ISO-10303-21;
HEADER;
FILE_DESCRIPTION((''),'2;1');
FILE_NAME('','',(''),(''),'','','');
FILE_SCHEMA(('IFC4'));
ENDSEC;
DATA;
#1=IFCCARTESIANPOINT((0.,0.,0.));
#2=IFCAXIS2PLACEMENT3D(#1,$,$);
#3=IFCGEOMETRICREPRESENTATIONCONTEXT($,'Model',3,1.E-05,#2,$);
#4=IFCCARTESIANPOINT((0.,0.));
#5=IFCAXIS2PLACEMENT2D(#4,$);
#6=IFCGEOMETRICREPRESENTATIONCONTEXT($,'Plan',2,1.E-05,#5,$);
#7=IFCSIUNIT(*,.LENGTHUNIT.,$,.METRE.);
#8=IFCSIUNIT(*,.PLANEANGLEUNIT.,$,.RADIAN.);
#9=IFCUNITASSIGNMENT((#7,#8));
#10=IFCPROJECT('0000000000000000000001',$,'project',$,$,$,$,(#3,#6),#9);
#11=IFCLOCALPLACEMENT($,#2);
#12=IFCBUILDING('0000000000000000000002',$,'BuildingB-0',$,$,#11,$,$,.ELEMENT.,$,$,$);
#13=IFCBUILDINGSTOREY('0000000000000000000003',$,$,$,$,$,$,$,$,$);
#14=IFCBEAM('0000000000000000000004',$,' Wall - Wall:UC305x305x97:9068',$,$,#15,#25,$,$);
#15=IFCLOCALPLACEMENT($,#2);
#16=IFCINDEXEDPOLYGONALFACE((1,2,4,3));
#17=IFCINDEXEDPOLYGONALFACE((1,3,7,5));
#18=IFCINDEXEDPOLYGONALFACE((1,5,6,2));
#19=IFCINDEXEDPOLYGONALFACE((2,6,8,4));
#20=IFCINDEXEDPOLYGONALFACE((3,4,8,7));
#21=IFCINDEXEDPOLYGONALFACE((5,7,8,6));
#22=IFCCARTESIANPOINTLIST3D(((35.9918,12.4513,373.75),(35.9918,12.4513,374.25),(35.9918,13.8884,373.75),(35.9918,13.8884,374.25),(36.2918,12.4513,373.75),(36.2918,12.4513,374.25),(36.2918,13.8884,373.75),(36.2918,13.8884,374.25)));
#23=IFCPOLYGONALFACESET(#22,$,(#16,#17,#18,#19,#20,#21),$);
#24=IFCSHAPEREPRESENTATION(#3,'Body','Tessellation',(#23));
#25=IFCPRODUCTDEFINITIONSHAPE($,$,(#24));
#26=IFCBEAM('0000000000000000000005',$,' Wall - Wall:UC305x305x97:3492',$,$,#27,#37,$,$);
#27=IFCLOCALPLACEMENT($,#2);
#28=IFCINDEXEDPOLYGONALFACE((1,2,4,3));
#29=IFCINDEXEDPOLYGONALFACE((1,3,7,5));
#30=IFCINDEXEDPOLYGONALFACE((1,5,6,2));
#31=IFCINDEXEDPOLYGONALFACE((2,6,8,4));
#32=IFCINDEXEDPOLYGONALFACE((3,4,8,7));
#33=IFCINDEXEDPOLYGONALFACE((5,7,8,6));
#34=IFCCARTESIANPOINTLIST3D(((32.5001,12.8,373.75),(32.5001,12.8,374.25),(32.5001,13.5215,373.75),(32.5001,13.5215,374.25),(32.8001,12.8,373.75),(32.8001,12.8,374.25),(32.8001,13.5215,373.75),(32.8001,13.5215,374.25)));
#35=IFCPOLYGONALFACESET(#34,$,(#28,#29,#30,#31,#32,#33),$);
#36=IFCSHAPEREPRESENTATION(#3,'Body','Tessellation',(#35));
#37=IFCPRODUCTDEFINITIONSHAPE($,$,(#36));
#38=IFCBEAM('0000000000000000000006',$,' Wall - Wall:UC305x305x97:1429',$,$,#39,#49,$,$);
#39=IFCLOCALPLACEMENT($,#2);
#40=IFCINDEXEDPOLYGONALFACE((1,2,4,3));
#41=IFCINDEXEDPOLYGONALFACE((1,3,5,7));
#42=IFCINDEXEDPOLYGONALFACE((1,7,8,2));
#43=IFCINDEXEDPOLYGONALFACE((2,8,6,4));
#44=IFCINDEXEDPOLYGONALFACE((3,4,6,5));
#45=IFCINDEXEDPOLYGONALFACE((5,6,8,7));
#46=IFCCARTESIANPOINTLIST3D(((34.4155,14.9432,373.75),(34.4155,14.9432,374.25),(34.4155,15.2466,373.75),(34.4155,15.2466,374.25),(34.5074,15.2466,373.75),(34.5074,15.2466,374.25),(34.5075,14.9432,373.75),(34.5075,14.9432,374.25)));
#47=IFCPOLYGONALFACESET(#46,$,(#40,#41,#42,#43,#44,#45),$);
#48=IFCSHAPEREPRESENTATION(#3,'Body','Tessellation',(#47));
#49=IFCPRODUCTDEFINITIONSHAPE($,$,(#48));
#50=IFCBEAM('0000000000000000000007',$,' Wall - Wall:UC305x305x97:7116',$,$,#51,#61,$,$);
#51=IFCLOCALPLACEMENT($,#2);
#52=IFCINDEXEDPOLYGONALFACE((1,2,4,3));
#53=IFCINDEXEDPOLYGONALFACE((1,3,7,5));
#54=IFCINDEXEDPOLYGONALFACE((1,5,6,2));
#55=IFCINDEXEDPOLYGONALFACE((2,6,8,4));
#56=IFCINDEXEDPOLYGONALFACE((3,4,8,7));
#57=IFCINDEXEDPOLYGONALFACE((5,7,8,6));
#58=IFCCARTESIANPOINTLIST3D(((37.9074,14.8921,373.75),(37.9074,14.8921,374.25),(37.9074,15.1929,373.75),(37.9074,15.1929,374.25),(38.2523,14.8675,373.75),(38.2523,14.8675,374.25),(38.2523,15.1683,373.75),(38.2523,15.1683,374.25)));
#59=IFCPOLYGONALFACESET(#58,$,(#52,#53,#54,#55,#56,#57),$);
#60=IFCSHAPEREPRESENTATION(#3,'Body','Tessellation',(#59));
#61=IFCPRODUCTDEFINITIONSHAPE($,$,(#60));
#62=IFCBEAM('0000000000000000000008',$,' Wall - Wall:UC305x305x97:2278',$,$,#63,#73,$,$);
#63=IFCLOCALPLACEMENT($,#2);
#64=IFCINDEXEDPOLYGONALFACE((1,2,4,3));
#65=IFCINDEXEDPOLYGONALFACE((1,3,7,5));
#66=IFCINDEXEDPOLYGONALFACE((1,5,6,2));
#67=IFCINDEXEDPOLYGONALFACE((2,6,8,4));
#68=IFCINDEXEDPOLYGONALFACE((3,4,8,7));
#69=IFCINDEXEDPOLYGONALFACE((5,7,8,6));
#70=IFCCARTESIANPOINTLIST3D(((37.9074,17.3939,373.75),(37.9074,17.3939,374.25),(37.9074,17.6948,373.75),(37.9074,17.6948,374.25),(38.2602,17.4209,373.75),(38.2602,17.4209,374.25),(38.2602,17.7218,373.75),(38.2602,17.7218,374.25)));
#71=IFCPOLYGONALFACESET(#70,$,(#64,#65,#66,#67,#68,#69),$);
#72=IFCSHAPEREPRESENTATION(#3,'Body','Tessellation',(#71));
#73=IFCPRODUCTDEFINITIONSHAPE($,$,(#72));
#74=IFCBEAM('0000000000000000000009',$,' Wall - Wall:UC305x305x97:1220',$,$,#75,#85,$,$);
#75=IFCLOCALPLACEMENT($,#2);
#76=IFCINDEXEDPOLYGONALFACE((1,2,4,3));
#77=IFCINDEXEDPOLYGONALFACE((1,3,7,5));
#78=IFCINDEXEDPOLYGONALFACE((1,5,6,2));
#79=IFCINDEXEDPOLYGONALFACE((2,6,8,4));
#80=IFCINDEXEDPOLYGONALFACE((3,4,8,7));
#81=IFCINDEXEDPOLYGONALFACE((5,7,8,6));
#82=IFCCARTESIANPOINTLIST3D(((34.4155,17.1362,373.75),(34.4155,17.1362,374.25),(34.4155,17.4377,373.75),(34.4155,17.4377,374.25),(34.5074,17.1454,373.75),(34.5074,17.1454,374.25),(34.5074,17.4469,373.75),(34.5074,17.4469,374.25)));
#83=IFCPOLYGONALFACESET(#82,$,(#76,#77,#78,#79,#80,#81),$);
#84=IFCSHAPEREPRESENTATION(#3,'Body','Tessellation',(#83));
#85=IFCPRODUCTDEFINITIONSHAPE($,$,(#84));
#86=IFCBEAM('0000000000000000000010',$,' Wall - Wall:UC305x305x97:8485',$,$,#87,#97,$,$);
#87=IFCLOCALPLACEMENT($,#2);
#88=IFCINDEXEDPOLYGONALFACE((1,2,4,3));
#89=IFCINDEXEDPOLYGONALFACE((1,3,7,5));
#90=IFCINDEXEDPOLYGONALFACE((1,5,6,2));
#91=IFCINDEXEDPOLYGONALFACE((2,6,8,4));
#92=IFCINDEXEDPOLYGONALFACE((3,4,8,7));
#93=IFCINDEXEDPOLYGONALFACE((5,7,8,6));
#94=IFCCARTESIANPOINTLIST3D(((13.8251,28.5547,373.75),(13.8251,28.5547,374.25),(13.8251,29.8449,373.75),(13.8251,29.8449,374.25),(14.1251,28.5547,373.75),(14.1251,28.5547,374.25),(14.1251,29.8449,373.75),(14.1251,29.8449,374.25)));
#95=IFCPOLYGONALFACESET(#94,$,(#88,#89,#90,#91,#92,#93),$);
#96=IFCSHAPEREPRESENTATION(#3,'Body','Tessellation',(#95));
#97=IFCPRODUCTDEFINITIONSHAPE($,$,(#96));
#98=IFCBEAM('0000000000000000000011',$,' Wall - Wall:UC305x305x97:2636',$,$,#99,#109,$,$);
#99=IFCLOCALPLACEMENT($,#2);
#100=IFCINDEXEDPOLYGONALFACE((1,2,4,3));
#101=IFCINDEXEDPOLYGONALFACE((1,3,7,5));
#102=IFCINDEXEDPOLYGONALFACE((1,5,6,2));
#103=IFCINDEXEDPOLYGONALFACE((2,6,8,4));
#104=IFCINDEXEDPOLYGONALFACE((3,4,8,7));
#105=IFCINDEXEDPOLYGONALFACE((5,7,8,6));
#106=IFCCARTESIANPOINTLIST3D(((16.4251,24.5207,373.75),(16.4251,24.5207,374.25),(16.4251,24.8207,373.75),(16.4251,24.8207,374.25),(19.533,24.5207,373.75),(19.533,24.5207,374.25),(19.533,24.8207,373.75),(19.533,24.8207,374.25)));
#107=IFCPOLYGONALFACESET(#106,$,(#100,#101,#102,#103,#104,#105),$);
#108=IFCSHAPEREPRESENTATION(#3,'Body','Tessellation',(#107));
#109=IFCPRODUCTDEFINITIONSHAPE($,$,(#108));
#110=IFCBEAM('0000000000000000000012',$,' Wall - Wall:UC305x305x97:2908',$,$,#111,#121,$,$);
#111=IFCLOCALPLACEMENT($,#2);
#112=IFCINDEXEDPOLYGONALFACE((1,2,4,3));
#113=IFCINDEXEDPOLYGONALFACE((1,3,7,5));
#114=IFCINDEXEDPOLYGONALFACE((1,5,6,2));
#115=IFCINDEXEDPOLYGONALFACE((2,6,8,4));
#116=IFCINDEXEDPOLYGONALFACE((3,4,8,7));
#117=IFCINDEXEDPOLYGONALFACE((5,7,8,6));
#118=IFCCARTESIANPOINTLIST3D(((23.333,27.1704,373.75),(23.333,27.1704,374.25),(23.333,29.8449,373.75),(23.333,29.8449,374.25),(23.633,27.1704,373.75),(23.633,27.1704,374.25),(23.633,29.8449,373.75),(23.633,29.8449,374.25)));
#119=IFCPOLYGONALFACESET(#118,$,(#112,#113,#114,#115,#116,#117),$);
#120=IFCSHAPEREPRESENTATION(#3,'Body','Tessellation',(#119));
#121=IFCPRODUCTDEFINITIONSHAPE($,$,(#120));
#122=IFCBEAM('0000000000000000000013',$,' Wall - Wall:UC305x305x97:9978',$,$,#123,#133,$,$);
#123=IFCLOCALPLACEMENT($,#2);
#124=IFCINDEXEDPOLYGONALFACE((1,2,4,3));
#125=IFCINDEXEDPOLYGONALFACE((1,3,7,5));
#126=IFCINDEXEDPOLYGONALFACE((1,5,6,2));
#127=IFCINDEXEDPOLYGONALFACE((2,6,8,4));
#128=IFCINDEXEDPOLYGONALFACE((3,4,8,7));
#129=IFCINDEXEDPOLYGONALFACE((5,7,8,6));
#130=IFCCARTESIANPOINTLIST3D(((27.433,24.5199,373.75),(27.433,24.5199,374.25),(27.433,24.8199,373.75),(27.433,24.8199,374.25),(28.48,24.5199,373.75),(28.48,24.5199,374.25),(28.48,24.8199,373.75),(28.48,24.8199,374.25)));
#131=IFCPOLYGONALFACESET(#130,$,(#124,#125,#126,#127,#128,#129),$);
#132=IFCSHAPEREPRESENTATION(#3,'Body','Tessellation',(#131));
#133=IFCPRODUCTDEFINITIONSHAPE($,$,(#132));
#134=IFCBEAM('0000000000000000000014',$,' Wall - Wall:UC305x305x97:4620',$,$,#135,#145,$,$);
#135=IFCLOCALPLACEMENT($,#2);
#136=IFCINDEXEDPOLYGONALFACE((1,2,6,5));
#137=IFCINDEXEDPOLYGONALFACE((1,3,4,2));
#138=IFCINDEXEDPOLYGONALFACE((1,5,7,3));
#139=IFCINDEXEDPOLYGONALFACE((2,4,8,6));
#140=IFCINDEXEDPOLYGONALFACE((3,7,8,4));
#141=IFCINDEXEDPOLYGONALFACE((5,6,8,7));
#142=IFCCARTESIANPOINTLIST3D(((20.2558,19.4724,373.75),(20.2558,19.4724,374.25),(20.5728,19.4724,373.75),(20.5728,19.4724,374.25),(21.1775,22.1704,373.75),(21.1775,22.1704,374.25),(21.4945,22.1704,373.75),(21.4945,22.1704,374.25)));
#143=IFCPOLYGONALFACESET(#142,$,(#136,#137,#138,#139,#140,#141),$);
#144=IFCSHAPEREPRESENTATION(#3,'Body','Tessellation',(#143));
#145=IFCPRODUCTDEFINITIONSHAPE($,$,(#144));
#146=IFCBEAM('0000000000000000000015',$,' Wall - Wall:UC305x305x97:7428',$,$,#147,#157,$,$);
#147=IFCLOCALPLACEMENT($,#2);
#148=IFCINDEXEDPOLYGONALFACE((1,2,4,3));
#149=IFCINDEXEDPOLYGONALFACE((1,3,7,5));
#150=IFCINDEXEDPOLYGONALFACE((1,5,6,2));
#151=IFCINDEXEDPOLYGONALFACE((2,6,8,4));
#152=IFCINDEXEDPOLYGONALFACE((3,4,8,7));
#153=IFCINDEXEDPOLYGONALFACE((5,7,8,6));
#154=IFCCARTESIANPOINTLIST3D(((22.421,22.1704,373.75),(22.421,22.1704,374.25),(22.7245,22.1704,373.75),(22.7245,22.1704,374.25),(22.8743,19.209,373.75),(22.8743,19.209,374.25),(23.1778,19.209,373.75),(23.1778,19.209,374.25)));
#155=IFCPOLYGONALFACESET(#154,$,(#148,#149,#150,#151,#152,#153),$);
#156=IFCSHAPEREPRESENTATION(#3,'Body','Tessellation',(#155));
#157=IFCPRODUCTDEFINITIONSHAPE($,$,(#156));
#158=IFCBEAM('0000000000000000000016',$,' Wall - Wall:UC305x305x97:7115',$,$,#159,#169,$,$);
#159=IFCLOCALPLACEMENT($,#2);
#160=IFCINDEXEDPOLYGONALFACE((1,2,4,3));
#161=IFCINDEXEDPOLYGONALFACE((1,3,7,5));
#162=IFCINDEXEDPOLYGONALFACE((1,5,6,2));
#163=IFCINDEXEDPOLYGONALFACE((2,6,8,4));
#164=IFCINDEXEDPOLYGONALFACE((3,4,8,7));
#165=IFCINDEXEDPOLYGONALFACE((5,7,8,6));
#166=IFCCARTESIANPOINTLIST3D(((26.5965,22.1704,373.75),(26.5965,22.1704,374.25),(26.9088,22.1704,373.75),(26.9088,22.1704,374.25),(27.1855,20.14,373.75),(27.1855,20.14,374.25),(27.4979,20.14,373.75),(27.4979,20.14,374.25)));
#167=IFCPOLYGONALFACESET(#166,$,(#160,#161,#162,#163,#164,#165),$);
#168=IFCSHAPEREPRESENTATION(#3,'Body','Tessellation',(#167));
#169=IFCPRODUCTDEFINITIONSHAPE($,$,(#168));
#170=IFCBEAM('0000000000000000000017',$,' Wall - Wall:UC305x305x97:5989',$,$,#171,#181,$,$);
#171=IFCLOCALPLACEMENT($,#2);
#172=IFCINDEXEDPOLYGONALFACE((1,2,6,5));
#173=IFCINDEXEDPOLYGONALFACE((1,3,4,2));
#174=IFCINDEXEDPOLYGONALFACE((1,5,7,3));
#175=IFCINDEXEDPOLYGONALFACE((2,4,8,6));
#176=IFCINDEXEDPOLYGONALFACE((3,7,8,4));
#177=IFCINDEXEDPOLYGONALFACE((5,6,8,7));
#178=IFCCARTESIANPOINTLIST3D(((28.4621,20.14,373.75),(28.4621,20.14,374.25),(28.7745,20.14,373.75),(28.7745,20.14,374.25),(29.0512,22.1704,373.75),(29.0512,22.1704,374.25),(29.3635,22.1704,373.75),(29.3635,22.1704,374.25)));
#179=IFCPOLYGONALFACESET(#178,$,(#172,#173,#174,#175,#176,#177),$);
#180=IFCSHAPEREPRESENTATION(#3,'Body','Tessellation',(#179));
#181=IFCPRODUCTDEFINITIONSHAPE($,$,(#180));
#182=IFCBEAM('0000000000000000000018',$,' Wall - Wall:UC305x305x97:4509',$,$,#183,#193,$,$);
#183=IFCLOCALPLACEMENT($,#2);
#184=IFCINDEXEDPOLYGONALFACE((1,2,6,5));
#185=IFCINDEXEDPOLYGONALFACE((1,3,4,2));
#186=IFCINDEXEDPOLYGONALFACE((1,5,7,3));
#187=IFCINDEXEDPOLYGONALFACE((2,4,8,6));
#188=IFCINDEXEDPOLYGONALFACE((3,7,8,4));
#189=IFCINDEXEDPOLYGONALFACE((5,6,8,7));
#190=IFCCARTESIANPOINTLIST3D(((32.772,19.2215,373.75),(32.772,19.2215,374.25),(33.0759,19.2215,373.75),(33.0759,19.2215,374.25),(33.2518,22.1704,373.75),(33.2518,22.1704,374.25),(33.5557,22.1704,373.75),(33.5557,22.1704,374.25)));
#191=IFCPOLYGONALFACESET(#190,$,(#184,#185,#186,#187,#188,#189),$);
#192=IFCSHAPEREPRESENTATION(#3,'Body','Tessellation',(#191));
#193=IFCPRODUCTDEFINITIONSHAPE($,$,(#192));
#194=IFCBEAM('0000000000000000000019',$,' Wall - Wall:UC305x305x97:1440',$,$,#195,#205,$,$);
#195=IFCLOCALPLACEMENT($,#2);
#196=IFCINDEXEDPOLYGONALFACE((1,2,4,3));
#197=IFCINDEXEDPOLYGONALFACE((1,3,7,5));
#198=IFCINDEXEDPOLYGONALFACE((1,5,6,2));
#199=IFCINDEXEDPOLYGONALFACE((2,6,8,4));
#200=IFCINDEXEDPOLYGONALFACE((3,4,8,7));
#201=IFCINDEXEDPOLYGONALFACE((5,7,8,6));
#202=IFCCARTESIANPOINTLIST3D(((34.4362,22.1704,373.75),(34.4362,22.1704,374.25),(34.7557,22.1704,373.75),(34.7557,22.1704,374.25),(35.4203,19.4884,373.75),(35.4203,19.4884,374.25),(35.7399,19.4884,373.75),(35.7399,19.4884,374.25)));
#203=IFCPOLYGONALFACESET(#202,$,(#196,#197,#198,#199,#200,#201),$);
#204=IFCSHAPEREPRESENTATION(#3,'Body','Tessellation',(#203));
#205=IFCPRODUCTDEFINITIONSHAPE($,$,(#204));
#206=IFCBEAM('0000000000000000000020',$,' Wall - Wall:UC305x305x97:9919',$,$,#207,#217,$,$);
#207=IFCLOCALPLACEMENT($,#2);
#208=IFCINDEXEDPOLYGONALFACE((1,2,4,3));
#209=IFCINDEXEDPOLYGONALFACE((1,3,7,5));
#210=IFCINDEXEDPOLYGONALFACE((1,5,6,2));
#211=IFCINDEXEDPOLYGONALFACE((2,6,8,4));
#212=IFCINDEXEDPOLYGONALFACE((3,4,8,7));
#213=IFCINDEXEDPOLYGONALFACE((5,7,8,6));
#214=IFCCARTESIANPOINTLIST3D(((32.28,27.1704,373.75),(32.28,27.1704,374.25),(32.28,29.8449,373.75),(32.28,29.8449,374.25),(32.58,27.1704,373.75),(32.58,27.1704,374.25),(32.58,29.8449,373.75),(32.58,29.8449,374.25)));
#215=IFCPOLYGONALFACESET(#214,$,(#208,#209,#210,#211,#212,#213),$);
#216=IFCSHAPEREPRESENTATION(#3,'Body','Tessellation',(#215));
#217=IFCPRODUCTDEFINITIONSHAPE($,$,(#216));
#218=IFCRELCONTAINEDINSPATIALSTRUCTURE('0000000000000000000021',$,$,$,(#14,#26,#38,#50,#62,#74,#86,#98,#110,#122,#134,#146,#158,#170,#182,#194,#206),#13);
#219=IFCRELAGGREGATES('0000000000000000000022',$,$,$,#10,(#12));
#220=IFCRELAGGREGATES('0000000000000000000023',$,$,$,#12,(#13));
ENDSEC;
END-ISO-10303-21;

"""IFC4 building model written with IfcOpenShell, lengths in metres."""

from ifc_helpers import new_model, si_unit, origin, origin_2d, place, context, project, spatial, polyline, outline, extrude, element, save


model = new_model("IFC4")

# Units and contexts
model_context = context("Model", 3, precision=1e-05, world=origin())
plan_context = context("Plan", 2, precision=1e-05, world=origin_2d())
ifc_project = project(units=[si_unit("LENGTHUNIT", "METRE"), si_unit("PLANEANGLEUNIT", "RADIAN")], contexts=[model_context, plan_context])

# Building, storey
building_placement = place(None, origin())
building = spatial("IfcBuilding", under=ifc_project, at=building_placement, Name="BuildingB-0", CompositionType="ELEMENT")
storey = spatial("IfcBuildingStorey", under=building)

# Beams
element("IfcBeam", 1, inside=storey, Name=" Wall - Wall:UC305x305x97:9068", context=model_context, shape_type="SweptSolid", body=[
    extrude(outline(polyline([(35.9918, 12.4513, 373.75), (36.2918, 12.4513, 373.75), (36.2918, 13.8884, 373.75), (35.9918, 13.8884, 373.75), (35.9918, 12.4513, 373.75)])), None, (0.0, 0.0, 1.0), 0.5),
])
element("IfcBeam", 2, inside=storey, Name=" Wall - Wall:UC305x305x97:3492", context=model_context, shape_type="SweptSolid", body=[
    extrude(outline(polyline([(32.5001, 12.8, 373.75), (32.8001, 12.8, 373.75), (32.8001, 13.5215, 373.75), (32.5001, 13.5215, 373.75), (32.5001, 12.8, 373.75)])), None, (0.0, 0.0, 1.0), 0.5),
])
element("IfcBeam", 3, inside=storey, Name=" Wall - Wall:UC305x305x97:1429", context=model_context, shape_type="SweptSolid", body=[
    extrude(outline(polyline([(34.4155, 14.9432, 373.75), (34.5075, 14.9432, 373.75), (34.5074, 15.2466, 373.75), (34.4155, 15.2466, 373.75), (34.4155, 14.9432, 373.75)])), None, (0.0, 0.0, 1.0), 0.5),
])
element("IfcBeam", 4, inside=storey, Name=" Wall - Wall:UC305x305x97:7116", context=model_context, shape_type="SweptSolid", body=[
    extrude(outline(polyline([(37.9074, 14.8921, 373.75), (38.2523, 14.8675, 373.75), (38.2523, 15.1683, 373.75), (37.9074, 15.1929, 373.75), (37.9074, 14.8921, 373.75)])), None, (0.0, 0.0, 1.0), 0.5),
])
element("IfcBeam", 5, inside=storey, Name=" Wall - Wall:UC305x305x97:2278", context=model_context, shape_type="SweptSolid", body=[
    extrude(outline(polyline([(37.9074, 17.3939, 373.75), (38.2602, 17.4209, 373.75), (38.2602, 17.7218, 373.75), (37.9074, 17.6948, 373.75), (37.9074, 17.3939, 373.75)])), None, (0.0, 0.0, 1.0), 0.5),
])
element("IfcBeam", 6, inside=storey, Name=" Wall - Wall:UC305x305x97:1220", context=model_context, shape_type="SweptSolid", body=[
    extrude(outline(polyline([(34.4155, 17.1362, 373.75), (34.5074, 17.1454, 373.75), (34.5074, 17.4469, 373.75), (34.4155, 17.4377, 373.75), (34.4155, 17.1362, 373.75)])), None, (0.0, 0.0, 1.0), 0.5),
])
element("IfcBeam", 7, inside=storey, Name=" Wall - Wall:UC305x305x97:8485", context=model_context, shape_type="SweptSolid", body=[
    extrude(outline(polyline([(13.8251, 28.5547, 373.75), (14.1251, 28.5547, 373.75), (14.1251, 29.8449, 373.75), (13.8251, 29.8449, 373.75), (13.8251, 28.5547, 373.75)])), None, (0.0, 0.0, 1.0), 0.5),
])
element("IfcBeam", 8, inside=storey, Name=" Wall - Wall:UC305x305x97:2636", context=model_context, shape_type="SweptSolid", body=[
    extrude(outline(polyline([(16.4251, 24.5207, 373.75), (16.4251, 24.8207, 373.75), (19.533, 24.8207, 373.75), (19.533, 24.5207, 373.75), (16.4251, 24.5207, 373.75)])), None, (0.0, 0.0, 1.0), 0.5),
])
element("IfcBeam", 9, inside=storey, Name=" Wall - Wall:UC305x305x97:2908", context=model_context, shape_type="SweptSolid", body=[
    extrude(outline(polyline([(23.333, 27.1704, 373.75), (23.633, 27.1704, 373.75), (23.633, 29.8449, 373.75), (23.333, 29.8449, 373.75), (23.333, 27.1704, 373.75)])), None, (0.0, 0.0, 1.0), 0.5),
])
element("IfcBeam", 10, inside=storey, Name=" Wall - Wall:UC305x305x97:9978", context=model_context, shape_type="SweptSolid", body=[
    extrude(outline(polyline([(27.433, 24.5199, 373.75), (27.433, 24.8199, 373.75), (28.48, 24.8199, 373.75), (28.48, 24.5199, 373.75), (27.433, 24.5199, 373.75)])), None, (0.0, 0.0, 1.0), 0.5),
])
element("IfcBeam", 11, inside=storey, Name=" Wall - Wall:UC305x305x97:4620", context=model_context, shape_type="SweptSolid", body=[
    extrude(outline(polyline([(20.2558, 19.4724, 373.75), (20.5728, 19.4724, 373.75), (21.4945, 22.1704, 373.75), (21.1775, 22.1704, 373.75), (20.2558, 19.4724, 373.75)])), None, (0.0, 0.0, 1.0), 0.5),
])
element("IfcBeam", 12, inside=storey, Name=" Wall - Wall:UC305x305x97:7428", context=model_context, shape_type="SweptSolid", body=[
    extrude(outline(polyline([(22.8743, 19.209, 373.75), (23.1778, 19.209, 373.75), (22.7245, 22.1704, 373.75), (22.421, 22.1704, 373.75), (22.8743, 19.209, 373.75)])), None, (0.0, 0.0, 1.0), 0.5),
])
element("IfcBeam", 13, inside=storey, Name=" Wall - Wall:UC305x305x97:7115", context=model_context, shape_type="SweptSolid", body=[
    extrude(outline(polyline([(27.1855, 20.14, 373.75), (27.4979, 20.14, 373.75), (26.9088, 22.1704, 373.75), (26.5965, 22.1704, 373.75), (27.1855, 20.14, 373.75)])), None, (0.0, 0.0, 1.0), 0.5),
])
element("IfcBeam", 14, inside=storey, Name=" Wall - Wall:UC305x305x97:5989", context=model_context, shape_type="SweptSolid", body=[
    extrude(outline(polyline([(28.4621, 20.14, 373.75), (29.0512, 22.1704, 373.75), (29.3635, 22.1704, 373.75), (28.7745, 20.14, 373.75), (28.4621, 20.14, 373.75)])), None, (0.0, 0.0, 1.0), 0.5),
])
element("IfcBeam", 15, inside=storey, Name=" Wall - Wall:UC305x305x97:4509", context=model_context, shape_type="SweptSolid", body=[
    extrude(outline(polyline([(32.772, 19.2215, 373.75), (33.0759, 19.2215, 373.75), (33.5557, 22.1704, 373.75), (33.2518, 22.1704, 373.75), (32.772, 19.2215, 373.75)])), None, (0.0, 0.0, 1.0), 0.5),
])
element("IfcBeam", 16, inside=storey, Name=" Wall - Wall:UC305x305x97:1440", context=model_context, shape_type="SweptSolid", body=[
    extrude(outline(polyline([(35.4203, 19.4884, 373.75), (35.7399, 19.4884, 373.75), (34.7557, 22.1704, 373.75), (34.4362, 22.1704, 373.75), (35.4203, 19.4884, 373.75)])), None, (0.0, 0.0, 1.0), 0.5),
])
element("IfcBeam", 17, inside=storey, Name=" Wall - Wall:UC305x305x97:9919", context=model_context, shape_type="SweptSolid", body=[
    extrude(outline(polyline([(32.28, 27.1704, 373.75), (32.58, 27.1704, 373.75), (32.58, 29.8449, 373.75), (32.28, 29.8449, 373.75), (32.28, 27.1704, 373.75)])), None, (0.0, 0.0, 1.0), 0.5),
])

save(model, "model.ifc")
